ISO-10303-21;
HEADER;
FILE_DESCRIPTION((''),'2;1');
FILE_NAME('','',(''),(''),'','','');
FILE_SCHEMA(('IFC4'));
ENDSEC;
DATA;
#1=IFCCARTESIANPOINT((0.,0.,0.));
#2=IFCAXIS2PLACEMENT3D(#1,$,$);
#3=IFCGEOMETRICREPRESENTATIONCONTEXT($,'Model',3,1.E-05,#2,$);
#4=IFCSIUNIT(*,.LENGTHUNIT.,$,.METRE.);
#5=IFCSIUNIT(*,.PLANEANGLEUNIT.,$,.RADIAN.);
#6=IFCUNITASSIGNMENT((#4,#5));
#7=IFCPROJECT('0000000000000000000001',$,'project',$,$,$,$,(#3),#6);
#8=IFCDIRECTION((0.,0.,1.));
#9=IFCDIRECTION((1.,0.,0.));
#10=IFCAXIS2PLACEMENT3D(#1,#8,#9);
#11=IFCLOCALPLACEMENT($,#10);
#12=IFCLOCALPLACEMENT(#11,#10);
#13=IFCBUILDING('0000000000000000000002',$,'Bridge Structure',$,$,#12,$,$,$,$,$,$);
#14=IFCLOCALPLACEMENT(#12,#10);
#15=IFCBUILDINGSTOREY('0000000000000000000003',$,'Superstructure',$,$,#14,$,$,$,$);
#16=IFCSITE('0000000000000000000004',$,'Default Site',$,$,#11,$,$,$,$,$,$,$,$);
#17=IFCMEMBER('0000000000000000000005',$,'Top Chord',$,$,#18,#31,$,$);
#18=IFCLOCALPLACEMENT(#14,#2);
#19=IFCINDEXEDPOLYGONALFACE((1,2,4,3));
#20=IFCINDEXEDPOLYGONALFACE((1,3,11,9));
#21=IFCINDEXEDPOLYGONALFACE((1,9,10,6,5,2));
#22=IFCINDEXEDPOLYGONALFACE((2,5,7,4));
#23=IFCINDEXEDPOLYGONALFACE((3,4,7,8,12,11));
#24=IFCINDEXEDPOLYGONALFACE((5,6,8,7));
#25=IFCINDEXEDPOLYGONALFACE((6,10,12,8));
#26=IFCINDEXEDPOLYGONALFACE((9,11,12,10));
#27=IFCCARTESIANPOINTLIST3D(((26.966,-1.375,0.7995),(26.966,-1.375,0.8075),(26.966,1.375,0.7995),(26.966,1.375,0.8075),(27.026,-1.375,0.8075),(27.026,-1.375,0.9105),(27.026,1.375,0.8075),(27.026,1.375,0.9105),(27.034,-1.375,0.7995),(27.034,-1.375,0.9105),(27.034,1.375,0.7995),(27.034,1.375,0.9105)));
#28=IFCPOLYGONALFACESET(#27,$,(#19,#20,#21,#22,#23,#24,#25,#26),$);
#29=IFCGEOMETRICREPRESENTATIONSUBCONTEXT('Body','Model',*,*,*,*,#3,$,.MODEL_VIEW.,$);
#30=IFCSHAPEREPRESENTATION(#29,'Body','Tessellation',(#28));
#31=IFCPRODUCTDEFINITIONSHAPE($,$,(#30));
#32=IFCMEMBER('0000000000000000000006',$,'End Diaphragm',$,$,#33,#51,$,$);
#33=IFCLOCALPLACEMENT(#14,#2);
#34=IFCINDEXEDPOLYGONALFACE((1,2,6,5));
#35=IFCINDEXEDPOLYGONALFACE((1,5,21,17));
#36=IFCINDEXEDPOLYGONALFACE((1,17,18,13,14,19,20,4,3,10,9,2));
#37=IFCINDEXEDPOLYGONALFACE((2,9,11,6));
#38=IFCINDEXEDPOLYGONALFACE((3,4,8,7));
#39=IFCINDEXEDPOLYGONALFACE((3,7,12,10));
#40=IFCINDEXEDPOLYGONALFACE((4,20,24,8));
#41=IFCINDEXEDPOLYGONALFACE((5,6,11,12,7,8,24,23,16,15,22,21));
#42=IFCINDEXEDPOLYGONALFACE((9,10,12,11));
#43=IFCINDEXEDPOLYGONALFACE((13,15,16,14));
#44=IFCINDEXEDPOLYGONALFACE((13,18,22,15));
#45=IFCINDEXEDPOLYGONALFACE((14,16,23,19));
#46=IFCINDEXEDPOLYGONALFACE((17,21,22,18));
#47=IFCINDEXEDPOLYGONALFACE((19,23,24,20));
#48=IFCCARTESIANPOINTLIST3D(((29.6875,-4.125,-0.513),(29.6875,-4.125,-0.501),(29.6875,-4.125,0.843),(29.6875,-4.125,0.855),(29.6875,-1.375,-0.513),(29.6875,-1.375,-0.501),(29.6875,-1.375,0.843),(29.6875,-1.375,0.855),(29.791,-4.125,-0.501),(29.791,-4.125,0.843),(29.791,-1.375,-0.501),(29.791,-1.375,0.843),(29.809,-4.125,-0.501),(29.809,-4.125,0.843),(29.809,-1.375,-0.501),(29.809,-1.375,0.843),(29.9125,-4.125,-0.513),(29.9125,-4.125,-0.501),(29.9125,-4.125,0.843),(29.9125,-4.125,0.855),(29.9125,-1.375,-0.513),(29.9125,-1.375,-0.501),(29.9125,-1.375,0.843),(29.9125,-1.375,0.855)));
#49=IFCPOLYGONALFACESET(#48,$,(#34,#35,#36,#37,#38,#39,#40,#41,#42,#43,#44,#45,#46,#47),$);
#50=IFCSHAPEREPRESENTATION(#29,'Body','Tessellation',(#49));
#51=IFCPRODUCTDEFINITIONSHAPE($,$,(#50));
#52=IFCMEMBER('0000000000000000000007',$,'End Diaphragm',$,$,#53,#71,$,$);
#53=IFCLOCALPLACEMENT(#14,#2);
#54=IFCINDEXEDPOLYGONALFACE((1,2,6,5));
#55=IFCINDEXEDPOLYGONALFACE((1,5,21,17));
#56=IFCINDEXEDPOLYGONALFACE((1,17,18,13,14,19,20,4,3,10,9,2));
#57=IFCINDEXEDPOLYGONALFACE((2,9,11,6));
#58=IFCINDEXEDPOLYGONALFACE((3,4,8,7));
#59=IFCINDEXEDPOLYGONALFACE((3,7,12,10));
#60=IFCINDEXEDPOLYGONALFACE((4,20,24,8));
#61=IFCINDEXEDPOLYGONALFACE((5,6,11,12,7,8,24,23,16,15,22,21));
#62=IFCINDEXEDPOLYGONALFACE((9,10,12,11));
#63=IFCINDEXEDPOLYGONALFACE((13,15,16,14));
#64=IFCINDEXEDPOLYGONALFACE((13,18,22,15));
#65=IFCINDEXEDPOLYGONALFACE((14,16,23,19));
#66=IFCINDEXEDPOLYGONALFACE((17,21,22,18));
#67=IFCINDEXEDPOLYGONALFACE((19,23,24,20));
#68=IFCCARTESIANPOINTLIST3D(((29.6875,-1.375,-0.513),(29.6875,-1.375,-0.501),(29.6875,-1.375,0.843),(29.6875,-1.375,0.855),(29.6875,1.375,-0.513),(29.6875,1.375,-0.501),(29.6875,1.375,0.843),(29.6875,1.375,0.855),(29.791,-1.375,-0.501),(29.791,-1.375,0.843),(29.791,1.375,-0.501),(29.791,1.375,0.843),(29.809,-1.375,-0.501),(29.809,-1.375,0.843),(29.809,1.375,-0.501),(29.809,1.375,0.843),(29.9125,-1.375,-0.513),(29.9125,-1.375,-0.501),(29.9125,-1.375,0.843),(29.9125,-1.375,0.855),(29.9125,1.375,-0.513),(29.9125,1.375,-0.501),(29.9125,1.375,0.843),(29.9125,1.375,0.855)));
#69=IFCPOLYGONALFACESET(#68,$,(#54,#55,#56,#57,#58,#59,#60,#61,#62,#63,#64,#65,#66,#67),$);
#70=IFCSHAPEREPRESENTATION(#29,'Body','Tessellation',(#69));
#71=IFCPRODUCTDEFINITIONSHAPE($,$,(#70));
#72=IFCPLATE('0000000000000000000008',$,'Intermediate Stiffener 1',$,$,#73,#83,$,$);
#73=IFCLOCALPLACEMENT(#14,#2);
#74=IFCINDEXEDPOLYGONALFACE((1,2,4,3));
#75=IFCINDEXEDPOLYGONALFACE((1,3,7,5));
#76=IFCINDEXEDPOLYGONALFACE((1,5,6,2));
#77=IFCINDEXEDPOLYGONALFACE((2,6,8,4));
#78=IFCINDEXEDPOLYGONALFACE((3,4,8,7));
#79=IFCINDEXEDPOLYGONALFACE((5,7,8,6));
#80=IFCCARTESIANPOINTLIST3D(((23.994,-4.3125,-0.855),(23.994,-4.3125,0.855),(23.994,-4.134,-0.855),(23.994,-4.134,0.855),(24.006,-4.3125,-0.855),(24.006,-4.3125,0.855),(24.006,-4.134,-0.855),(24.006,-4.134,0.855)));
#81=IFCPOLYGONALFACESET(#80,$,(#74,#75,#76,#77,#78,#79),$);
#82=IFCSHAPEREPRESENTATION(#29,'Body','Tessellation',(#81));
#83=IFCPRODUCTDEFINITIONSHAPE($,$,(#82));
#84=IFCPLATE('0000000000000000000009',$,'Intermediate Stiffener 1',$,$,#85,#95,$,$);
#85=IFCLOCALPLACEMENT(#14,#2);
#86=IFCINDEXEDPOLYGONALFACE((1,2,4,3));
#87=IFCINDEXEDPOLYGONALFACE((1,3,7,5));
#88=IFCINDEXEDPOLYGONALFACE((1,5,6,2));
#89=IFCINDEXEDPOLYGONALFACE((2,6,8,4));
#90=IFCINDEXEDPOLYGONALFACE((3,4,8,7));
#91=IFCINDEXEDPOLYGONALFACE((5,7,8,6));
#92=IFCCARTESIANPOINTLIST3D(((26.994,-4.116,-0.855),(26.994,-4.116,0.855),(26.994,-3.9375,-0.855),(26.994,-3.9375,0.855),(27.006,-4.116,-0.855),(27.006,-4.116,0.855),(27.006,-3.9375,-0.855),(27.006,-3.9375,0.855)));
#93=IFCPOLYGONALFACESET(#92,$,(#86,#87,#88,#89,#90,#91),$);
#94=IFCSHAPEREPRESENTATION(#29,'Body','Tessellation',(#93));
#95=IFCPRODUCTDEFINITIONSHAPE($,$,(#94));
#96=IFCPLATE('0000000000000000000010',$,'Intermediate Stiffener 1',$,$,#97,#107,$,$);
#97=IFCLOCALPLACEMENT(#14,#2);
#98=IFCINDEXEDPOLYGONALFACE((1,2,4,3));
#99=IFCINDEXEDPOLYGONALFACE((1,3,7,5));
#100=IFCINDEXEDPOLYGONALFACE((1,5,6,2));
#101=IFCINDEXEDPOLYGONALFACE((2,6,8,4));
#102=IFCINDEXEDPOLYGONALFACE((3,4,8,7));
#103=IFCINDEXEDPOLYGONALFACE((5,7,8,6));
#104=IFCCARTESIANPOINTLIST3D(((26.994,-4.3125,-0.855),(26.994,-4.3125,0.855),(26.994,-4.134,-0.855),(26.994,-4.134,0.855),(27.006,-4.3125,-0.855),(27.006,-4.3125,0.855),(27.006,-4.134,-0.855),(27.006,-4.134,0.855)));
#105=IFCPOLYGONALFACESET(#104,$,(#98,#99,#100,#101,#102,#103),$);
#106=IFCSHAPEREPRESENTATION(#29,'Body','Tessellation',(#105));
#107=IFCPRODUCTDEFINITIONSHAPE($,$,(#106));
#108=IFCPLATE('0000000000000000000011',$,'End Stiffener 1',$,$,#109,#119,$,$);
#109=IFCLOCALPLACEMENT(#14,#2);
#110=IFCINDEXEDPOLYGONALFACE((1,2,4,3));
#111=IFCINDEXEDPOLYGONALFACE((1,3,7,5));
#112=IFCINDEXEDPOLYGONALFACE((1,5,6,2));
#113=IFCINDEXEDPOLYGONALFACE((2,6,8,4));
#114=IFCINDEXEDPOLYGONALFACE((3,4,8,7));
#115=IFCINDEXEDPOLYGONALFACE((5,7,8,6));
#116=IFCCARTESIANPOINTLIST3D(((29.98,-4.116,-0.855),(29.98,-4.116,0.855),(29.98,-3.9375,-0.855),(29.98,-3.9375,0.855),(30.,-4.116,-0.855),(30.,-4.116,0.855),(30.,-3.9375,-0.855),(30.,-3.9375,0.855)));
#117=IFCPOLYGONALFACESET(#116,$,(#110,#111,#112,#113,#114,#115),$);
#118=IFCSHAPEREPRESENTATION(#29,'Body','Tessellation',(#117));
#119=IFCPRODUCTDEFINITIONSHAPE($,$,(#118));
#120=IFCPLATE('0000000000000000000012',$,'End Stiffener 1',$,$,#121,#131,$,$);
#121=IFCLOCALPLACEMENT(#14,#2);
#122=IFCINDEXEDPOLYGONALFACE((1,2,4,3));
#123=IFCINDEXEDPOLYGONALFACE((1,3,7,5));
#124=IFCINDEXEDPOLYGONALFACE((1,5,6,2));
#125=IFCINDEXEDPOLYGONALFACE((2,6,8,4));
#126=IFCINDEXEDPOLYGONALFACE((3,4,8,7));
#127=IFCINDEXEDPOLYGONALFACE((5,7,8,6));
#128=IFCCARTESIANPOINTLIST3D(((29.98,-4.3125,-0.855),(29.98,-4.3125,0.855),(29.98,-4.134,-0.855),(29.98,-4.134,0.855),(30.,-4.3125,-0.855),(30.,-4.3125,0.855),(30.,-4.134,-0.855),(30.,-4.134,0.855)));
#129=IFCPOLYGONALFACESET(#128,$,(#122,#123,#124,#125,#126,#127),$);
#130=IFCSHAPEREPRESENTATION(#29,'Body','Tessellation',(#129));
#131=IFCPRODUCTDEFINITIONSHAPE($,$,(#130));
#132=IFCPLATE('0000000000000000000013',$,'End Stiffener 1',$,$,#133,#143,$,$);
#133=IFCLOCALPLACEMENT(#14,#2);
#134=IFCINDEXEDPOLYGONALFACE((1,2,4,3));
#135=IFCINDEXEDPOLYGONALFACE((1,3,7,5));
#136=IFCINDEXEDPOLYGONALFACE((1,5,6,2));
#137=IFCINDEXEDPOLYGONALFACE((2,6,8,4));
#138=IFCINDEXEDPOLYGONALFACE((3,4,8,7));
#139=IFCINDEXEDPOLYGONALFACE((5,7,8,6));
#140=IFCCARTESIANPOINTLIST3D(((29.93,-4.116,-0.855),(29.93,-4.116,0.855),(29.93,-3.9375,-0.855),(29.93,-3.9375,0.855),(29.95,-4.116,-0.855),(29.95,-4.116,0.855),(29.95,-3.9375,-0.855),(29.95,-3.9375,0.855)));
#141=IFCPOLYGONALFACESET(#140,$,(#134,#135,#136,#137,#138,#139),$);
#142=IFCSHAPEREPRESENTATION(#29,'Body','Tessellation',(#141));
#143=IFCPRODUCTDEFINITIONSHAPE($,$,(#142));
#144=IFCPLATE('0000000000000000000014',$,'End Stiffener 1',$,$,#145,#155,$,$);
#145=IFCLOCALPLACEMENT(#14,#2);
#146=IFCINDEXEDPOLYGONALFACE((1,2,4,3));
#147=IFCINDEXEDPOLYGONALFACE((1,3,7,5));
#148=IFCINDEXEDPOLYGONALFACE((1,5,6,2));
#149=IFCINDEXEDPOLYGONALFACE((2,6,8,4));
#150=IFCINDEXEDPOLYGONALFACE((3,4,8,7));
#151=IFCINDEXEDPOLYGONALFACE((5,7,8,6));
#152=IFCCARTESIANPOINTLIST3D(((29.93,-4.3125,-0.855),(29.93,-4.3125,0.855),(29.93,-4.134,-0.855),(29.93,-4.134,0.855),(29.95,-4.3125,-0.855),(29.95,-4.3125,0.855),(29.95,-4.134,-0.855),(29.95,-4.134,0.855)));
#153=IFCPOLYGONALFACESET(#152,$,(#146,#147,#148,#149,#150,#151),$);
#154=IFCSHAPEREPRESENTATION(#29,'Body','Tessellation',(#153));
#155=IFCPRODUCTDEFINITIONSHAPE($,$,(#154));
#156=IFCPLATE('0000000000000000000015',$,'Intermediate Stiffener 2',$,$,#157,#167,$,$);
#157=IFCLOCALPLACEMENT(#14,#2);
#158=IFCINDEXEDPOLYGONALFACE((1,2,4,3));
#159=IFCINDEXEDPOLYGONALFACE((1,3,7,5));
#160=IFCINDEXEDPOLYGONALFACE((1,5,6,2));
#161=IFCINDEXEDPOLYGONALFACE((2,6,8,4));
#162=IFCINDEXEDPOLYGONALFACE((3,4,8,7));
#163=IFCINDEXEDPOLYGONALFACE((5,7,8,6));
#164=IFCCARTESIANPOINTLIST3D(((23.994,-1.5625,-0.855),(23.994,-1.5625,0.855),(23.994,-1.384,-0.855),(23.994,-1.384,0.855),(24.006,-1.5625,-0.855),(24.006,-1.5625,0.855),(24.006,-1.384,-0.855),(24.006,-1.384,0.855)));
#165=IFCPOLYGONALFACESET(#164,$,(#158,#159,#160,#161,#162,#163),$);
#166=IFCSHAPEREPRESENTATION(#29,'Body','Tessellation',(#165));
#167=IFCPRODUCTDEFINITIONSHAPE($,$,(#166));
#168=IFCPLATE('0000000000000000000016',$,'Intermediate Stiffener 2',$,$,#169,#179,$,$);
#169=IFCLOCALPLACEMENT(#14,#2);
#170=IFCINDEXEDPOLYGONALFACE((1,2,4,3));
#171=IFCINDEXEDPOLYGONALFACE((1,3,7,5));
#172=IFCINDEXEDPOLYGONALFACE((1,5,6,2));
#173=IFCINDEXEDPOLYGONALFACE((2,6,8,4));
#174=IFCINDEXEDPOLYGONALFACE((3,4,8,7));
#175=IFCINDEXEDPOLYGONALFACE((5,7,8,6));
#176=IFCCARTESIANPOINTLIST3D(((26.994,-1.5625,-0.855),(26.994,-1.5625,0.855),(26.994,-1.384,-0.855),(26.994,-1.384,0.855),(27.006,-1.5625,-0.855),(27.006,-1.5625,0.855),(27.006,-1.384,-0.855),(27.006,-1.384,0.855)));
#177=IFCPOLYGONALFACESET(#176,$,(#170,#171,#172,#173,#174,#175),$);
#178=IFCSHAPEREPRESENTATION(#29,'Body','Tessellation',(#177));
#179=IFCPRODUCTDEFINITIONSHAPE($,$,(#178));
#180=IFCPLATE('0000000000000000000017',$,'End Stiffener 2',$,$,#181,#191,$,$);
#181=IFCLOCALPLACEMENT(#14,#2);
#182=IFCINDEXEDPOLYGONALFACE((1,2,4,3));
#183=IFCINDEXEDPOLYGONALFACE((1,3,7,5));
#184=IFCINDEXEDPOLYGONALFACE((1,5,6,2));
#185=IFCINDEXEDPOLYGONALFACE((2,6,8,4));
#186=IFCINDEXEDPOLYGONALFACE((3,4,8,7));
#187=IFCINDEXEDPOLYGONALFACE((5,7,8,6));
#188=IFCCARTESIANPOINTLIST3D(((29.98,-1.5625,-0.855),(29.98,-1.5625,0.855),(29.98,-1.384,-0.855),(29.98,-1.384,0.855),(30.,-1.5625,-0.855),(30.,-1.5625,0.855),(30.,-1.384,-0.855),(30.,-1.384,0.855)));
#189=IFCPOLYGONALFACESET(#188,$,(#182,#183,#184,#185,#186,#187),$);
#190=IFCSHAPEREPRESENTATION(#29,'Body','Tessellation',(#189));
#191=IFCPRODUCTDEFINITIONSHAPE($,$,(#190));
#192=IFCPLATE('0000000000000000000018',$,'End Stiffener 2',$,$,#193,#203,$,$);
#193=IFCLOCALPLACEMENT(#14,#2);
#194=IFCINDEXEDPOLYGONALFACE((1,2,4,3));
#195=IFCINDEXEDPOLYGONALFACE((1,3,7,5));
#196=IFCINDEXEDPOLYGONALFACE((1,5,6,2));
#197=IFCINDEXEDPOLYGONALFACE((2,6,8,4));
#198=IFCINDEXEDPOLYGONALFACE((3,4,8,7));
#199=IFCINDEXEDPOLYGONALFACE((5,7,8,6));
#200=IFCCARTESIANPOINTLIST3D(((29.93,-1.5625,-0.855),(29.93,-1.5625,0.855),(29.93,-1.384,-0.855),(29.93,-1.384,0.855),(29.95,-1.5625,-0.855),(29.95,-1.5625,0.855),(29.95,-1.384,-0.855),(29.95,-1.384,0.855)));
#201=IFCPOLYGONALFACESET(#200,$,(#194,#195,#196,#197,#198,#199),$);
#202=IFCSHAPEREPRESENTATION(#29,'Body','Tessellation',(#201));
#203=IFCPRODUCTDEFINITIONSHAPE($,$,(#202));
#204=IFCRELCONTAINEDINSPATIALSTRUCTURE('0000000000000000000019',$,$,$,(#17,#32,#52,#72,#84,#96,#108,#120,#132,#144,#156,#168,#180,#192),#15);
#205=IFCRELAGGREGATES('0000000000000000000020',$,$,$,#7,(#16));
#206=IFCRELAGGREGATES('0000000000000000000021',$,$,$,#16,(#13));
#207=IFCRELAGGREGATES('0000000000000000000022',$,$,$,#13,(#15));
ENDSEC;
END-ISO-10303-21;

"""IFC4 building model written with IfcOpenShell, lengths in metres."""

from ifc_helpers import new_model, si_unit, frame, origin, origin_with_axes, origin_2d_with_axis, place, context, subcontext, project, spatial, rectangle, i_section, l_section, extrude, element, save


model = new_model("IFC4")

# Units and contexts
model_context = context("Model", 3, precision=1e-05, world=origin())
body_context = subcontext(model_context, "Body", "Model", "MODEL_VIEW")
ifc_project = project(units=[si_unit("LENGTHUNIT", "METRE"), si_unit("PLANEANGLEUNIT", "RADIAN")], contexts=[model_context])

# Site, building, storey
site_placement = place(None, origin_with_axes())
site = spatial("IfcSite", under=ifc_project, at=site_placement, Name="Default Site")
building_placement = place(site_placement, origin_with_axes())
building = spatial("IfcBuilding", under=site, at=building_placement, Name="Bridge Structure")
storey_placement = place(building_placement, origin_with_axes())
storey = spatial("IfcBuildingStorey", under=building, at=storey_placement, Name="Superstructure")

# Members
for number, where, z_axis, x_axis, name in (
    (1, (27.0, -1.375, 0.855), (0.0, 1.0, 0.0), (-1.0, 0.0, 0.0), "Top Chord"),
):
    element("IfcMember", number, at=place(storey_placement, frame(where, z_axis=z_axis, x_axis=x_axis)), inside=storey, Name=name, context=body_context, shape_type="SweptSolid", body=[
        extrude(l_section(Depth=0.111, Width=0.068, Thickness=0.008, at=origin_2d_with_axis()), origin_with_axes(), (0.0, 0.0, 1.0), 2.75),
    ])
for number, where, z_axis, x_axis, name in (
    (2, (29.8, -4.125, 0.171), (0.0, 1.0, 0.0), (-1.0, 0.0, 0.0), "End Diaphragm"),
    (3, (29.8, -1.375, 0.171), (0.0, 1.0, 0.0), (-1.0, 0.0, 0.0), "End Diaphragm"),
):
    element("IfcMember", number, at=place(storey_placement, frame(where, z_axis=z_axis, x_axis=x_axis)), inside=storey, Name=name, context=body_context, shape_type="SweptSolid", body=[
        extrude(i_section(OverallWidth=0.225, OverallDepth=1.368, WebThickness=0.018, FlangeThickness=0.012, at=origin_2d_with_axis()), origin_with_axes(), (0.0, 0.0, 1.0), 2.75),
    ])

# Plates
for number, where, z_axis, x_axis, name in (
    (4, (24.0, -4.2233, -0.855), (0.0, 0.0, 1.0), (1.0, 0.0, 0.0), "Intermediate Stiffener 1"),
    (5, (27.0, -4.0267, -0.855), (0.0, 0.0, 1.0), (1.0, 0.0, 0.0), "Intermediate Stiffener 1"),
    (6, (27.0, -4.2233, -0.855), (0.0, 0.0, 1.0), (1.0, 0.0, 0.0), "Intermediate Stiffener 1"),
):
    element("IfcPlate", number, at=place(storey_placement, frame(where, z_axis=z_axis, x_axis=x_axis)), inside=storey, Name=name, context=body_context, shape_type="SweptSolid", body=[
        extrude(rectangle(XDim=0.012, YDim=0.1785, at=origin_2d_with_axis()), origin_with_axes(), (0.0, 0.0, 1.0), 1.71),
    ])
for number, where, z_axis, x_axis, name in (
    (7, (29.99, -4.0267, -0.855), (0.0, 0.0, 1.0), (1.0, 0.0, 0.0), "End Stiffener 1"),
    (8, (29.99, -4.2233, -0.855), (0.0, 0.0, 1.0), (1.0, 0.0, 0.0), "End Stiffener 1"),
    (9, (29.94, -4.0267, -0.855), (0.0, 0.0, 1.0), (1.0, 0.0, 0.0), "End Stiffener 1"),
    (10, (29.94, -4.2233, -0.855), (0.0, 0.0, 1.0), (1.0, 0.0, 0.0), "End Stiffener 1"),
):
    element("IfcPlate", number, at=place(storey_placement, frame(where, z_axis=z_axis, x_axis=x_axis)), inside=storey, Name=name, context=body_context, shape_type="SweptSolid", body=[
        extrude(rectangle(XDim=0.02, YDim=0.1785, at=origin_2d_with_axis()), origin_with_axes(), (0.0, 0.0, 1.0), 1.71),
    ])
for number, where, z_axis, x_axis, name in (
    (11, (24.0, -1.4732, -0.855), (0.0, 0.0, 1.0), (1.0, 0.0, 0.0), "Intermediate Stiffener 2"),
    (12, (27.0, -1.4732, -0.855), (0.0, 0.0, 1.0), (1.0, 0.0, 0.0), "Intermediate Stiffener 2"),
):
    element("IfcPlate", number, at=place(storey_placement, frame(where, z_axis=z_axis, x_axis=x_axis)), inside=storey, Name=name, context=body_context, shape_type="SweptSolid", body=[
        extrude(rectangle(XDim=0.012, YDim=0.1785, at=origin_2d_with_axis()), origin_with_axes(), (0.0, 0.0, 1.0), 1.71),
    ])
for number, where, z_axis, x_axis, name in (
    (13, (29.99, -1.4732, -0.855), (0.0, 0.0, 1.0), (1.0, 0.0, 0.0), "End Stiffener 2"),
    (14, (29.94, -1.4732, -0.855), (0.0, 0.0, 1.0), (1.0, 0.0, 0.0), "End Stiffener 2"),
):
    element("IfcPlate", number, at=place(storey_placement, frame(where, z_axis=z_axis, x_axis=x_axis)), inside=storey, Name=name, context=body_context, shape_type="SweptSolid", body=[
        extrude(rectangle(XDim=0.02, YDim=0.1785, at=origin_2d_with_axis()), origin_with_axes(), (0.0, 0.0, 1.0), 1.71),
    ])

save(model, "model.ifc")
